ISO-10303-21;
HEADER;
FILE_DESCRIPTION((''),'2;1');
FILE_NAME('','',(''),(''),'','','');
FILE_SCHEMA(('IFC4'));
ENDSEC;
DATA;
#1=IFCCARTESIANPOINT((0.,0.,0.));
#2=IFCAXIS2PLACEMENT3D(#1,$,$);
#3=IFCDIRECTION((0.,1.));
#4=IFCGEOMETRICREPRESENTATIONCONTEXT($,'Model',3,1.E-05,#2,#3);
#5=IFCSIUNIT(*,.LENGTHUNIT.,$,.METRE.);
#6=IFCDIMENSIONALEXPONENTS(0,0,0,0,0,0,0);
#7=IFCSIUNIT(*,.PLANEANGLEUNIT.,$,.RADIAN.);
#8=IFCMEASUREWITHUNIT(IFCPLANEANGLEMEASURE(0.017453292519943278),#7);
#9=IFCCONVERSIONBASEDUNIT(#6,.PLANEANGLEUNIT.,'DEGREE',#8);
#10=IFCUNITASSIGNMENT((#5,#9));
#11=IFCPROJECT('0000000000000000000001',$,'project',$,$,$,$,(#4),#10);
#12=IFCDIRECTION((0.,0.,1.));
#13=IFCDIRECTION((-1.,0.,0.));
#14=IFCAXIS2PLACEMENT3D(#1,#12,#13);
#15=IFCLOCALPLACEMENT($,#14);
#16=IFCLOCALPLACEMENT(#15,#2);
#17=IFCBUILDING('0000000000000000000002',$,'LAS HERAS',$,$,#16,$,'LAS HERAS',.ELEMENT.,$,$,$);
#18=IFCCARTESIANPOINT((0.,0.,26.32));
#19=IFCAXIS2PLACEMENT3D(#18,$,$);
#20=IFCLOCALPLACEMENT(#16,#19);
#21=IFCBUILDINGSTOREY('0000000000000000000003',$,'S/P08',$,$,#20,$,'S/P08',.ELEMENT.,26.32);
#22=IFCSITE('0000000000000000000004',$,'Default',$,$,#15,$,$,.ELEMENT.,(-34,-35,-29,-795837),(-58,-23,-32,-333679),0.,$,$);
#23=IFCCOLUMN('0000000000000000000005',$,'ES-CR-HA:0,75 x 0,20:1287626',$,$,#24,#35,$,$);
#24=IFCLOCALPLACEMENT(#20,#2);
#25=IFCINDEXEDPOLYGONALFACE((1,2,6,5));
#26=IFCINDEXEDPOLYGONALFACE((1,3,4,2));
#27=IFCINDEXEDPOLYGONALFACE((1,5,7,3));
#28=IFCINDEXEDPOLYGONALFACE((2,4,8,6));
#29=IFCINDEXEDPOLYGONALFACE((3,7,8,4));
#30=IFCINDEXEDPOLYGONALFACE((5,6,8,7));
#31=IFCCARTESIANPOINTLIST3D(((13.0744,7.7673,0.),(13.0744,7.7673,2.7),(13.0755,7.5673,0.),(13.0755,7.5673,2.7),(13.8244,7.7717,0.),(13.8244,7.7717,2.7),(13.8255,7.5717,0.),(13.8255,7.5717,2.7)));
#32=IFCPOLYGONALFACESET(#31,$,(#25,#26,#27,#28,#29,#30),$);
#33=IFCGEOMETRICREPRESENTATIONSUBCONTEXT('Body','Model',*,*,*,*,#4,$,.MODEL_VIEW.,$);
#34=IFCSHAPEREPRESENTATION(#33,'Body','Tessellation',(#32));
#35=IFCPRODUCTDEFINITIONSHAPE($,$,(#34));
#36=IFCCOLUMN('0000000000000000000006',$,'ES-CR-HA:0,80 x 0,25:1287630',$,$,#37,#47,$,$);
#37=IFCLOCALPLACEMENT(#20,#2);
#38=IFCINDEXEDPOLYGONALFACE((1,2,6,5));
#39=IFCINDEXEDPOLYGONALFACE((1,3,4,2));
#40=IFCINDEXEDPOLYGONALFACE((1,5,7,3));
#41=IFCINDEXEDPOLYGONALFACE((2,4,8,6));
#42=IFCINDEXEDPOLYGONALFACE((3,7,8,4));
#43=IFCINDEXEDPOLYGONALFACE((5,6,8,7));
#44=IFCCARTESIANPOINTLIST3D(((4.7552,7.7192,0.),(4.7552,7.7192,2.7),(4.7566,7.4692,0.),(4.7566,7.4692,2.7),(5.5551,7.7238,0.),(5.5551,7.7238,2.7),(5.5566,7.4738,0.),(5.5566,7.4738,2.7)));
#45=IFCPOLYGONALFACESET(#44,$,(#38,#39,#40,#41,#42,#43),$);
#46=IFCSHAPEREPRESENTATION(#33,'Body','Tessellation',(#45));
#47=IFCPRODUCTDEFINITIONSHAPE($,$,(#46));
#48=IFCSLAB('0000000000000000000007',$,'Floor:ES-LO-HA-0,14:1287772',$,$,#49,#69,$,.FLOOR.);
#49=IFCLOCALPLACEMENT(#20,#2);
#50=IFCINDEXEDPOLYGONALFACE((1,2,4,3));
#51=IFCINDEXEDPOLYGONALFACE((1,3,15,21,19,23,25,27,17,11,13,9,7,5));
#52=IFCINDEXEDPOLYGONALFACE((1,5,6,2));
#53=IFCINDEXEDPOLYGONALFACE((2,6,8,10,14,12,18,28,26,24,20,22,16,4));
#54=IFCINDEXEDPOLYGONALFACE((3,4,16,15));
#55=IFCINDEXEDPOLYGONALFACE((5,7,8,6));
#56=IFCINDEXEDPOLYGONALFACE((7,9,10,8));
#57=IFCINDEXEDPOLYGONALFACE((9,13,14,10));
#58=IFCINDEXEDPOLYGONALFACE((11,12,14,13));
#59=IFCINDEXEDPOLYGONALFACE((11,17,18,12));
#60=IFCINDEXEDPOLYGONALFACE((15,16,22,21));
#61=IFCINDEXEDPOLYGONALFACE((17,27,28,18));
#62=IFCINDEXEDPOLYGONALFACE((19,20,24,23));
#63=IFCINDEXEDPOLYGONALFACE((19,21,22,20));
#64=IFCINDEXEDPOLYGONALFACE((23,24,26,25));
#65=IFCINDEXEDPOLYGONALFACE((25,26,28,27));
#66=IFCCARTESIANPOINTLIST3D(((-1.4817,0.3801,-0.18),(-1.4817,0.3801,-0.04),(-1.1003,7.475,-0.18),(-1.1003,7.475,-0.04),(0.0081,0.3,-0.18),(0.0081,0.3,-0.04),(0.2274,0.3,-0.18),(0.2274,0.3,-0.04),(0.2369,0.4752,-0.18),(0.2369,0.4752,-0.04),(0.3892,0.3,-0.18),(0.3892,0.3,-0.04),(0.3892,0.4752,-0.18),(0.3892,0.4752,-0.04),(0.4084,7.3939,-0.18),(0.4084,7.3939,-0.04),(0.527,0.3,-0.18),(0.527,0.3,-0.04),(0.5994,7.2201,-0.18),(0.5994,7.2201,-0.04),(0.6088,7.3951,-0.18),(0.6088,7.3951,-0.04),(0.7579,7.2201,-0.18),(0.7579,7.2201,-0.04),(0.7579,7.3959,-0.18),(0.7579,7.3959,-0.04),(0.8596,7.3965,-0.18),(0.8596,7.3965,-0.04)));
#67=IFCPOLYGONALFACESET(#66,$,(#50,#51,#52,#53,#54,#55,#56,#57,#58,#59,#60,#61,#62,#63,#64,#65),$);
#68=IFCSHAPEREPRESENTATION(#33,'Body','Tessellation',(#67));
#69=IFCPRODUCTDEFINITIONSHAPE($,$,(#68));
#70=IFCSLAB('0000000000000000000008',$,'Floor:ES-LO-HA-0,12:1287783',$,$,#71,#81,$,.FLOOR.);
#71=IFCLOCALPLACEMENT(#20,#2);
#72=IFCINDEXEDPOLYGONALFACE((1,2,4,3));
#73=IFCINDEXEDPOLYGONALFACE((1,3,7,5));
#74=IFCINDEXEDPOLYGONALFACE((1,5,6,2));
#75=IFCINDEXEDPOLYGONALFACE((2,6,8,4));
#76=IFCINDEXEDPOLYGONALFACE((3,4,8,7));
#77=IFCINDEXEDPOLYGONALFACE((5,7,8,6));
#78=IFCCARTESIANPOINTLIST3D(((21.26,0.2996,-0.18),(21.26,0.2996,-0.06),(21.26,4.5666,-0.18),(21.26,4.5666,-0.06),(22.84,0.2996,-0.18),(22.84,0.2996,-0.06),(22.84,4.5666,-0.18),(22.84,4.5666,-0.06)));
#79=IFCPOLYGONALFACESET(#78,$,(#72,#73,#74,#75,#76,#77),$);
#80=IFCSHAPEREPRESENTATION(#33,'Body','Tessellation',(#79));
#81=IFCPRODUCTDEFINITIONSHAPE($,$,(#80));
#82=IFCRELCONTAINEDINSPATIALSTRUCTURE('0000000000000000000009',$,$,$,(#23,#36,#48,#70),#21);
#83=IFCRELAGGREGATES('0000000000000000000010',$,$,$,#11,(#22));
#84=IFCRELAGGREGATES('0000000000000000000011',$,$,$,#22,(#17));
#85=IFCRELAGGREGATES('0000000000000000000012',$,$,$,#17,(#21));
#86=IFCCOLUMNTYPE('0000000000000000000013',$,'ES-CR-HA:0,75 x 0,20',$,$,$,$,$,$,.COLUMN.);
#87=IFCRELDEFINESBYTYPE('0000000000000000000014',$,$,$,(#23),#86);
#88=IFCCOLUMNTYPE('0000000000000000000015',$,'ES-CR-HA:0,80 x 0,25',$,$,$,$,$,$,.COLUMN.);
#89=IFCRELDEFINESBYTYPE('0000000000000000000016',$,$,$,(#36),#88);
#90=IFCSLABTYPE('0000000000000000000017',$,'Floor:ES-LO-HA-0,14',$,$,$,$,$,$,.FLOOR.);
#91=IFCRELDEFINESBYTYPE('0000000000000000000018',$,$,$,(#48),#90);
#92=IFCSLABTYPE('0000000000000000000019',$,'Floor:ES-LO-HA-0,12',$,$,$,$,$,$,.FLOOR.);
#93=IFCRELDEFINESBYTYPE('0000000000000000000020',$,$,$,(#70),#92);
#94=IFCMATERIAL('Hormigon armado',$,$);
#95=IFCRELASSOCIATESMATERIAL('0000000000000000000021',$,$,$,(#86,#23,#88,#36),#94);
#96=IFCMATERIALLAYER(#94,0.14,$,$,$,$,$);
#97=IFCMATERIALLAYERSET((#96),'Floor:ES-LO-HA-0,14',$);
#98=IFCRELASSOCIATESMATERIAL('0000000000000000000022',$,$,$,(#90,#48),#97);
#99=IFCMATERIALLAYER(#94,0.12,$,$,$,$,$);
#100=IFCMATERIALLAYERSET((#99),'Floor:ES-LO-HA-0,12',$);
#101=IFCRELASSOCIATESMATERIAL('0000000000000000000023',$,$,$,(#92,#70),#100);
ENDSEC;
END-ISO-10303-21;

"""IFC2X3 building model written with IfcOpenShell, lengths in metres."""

from ifc_helpers import new_model, entity, si_unit, converted_unit, direction, frame, frame_2d, origin, place, context, subcontext, project, spatial, polyline, rectangle, outline, extrude, source, transform, mapped, material, layer, layer_set, layer_usage, type_object, type_shapes, element, save


model = new_model("IFC2X3")

# Units and contexts
model_context = context("Model", 3, precision=1e-05, world=origin(), true_north=direction((0.0, 1.0)))
body_context = subcontext(model_context, "Body", "Model", "MODEL_VIEW")
ifc_project = project(units=[si_unit("LENGTHUNIT", "METRE"), converted_unit("PLANEANGLEUNIT", "DEGREE", entity("IfcPlaneAngleMeasure", 0.017453292519943278), si_unit("PLANEANGLEUNIT", "RADIAN"), dimensions=[0, 0, 0, 0, 0, 0, 0])], contexts=[model_context])

# Site, building, storey
site_placement = place(None, frame((0.0, 0.0, 0.0), z_axis=(0.0, 0.0, 1.0), x_axis=(-1.0, 0.0, 0.0)))
site = spatial("IfcSite", under=ifc_project, at=site_placement, Name="Default", CompositionType="ELEMENT", RefLatitude=(-34, -35, -29, -795837), RefLongitude=(-58, -23, -32, -333679), RefElevation=0.0)
building_placement = place(site_placement, origin())
building = spatial("IfcBuilding", under=site, at=building_placement, Name="LAS HERAS", LongName="LAS HERAS", CompositionType="ELEMENT")
storey_placement = place(building_placement, frame((0.0, 0.0, 26.32)))
storey = spatial("IfcBuildingStorey", under=building, at=storey_placement, Name="S/P08", LongName="S/P08", CompositionType="ELEMENT", Elevation=26.32)

# Columns
ifc_material = material(Name="Hormigon armado")
column_type_1 = type_object("IfcColumnType", Name="ES-CR-HA:0,75 x 0,20", PredefinedType="COLUMN", material=ifc_material)
shared_shape_1 = source(origin(), body_context, "Body", "SweptSolid", [
    extrude(rectangle(XDim=0.75, YDim=0.2, at=frame_2d((0.0, 0.0), x_axis=(1.0, 0.0))), frame((13.4499, 7.6695, 26.32), z_axis=(0.0, 0.0, 1.0), x_axis=(-0.999983, -0.005788, 0.0)), (0.0, 0.0, 1.0), 2.7),
])
type_shapes(column_type_1, [shared_shape_1])
column_1_placement = place(storey_placement, frame((0.0, 0.0, -26.32)))
element("IfcColumn", 1, at=column_1_placement, inside=storey, type_object=column_type_1, material=ifc_material, Name="ES-CR-HA:0,75 x 0,20:1287626", context=body_context, shape_type="MappedRepresentation", body=[
    mapped(shared_shape_1, transform((0.0, 0.0, 0.0), scale=1.0)),
])
column_type_2 = type_object("IfcColumnType", Name="ES-CR-HA:0,80 x 0,25", PredefinedType="COLUMN", material=ifc_material)
shared_shape_2 = source(origin(), body_context, "Body", "SweptSolid", [
    extrude(rectangle(XDim=0.8, YDim=0.25, at=frame_2d((0.0, 0.0), x_axis=(1.0, 0.0))), frame((5.1559, 7.5965, 26.32), z_axis=(0.0, 0.0, 1.0), x_axis=(-0.999983, -0.005788, 0.0)), (0.0, 0.0, 1.0), 2.7),
])
type_shapes(column_type_2, [shared_shape_2])
column_2_placement = place(storey_placement, frame((0.0, 0.0, -26.32)))
element("IfcColumn", 2, at=column_2_placement, inside=storey, type_object=column_type_2, material=ifc_material, Name="ES-CR-HA:0,80 x 0,25:1287630", context=body_context, shape_type="MappedRepresentation", body=[
    mapped(shared_shape_2, transform((0.0, 0.0, 0.0), scale=1.0)),
])

# Slab, openings
ifc_layer_1 = layer(ifc_material, 0.14)
ifc_layer_set_1 = layer_set([ifc_layer_1], Name="Floor:ES-LO-HA-0,14")
ifc_layer_usage_1 = layer_usage(ifc_layer_set_1, "AXIS3", "POSITIVE", 0.0)
slab_type_1 = type_object("IfcSlabType", Name="Floor:ES-LO-HA-0,14", PredefinedType="FLOOR", material=ifc_layer_set_1)
slab_1_placement = place(storey_placement, origin())
slab_1 = element("IfcSlab", 3, at=slab_1_placement, inside=storey, type_object=slab_type_1, material=ifc_layer_usage_1, Name="Floor:ES-LO-HA-0,14:1287772", PredefinedType="FLOOR", context=body_context, shape_type="SweptSolid", body=[
    extrude(outline(polyline([(-0.2993, -3.5591), (-0.1615, -3.5591), (-0.1615, -3.3839), (-0.0091, -3.3839), (0.0003, -3.5591), (0.2196, -3.5591), (1.7094, -3.479), (1.328, 3.6159), (-0.1807, 3.5348), (-0.3811, 3.536), (-0.3717, 3.3611), (-0.5302, 3.3611), (-0.5302, 3.5368), (-0.6319, 3.5374), (-0.2993, -3.5591)])), frame((0.2277, 3.8591, -0.04), z_axis=(0.0, 0.0, -1.0), x_axis=(-1.0, 0.0, 0.0)), (0.0, 0.0, 1.0), 0.14),
])
opening_1_placement = place(slab_1_placement, origin())
element("IfcOpeningElement", 4, at=opening_1_placement, cuts=slab_1, ObjectType="Opening", context=body_context, shape_type="SweptSolid", body=[
    extrude(outline(polyline([(0.2369, 0.4752), (0.2274, 0.3), (0.3892, 0.3), (0.3892, 0.4752), (0.2369, 0.4752)])), frame((0.0, 0.0, -0.04)), (0.0, 0.0, -1.0), 0.14),
])
opening_2_placement = place(slab_1_placement, origin())
element("IfcOpeningElement", 5, at=opening_2_placement, cuts=slab_1, ObjectType="Opening", context=body_context, shape_type="SweptSolid", body=[
    extrude(outline(polyline([(0.7579, 7.2201), (0.7579, 7.3959), (0.6088, 7.3951), (0.5994, 7.2201), (0.7579, 7.2201)])), frame((0.0, 0.0, -0.04)), (0.0, 0.0, -1.0), 0.14),
])

# Slab
ifc_layer_2 = layer(ifc_material, 0.12)
ifc_layer_set_2 = layer_set([ifc_layer_2], Name="Floor:ES-LO-HA-0,12")
ifc_layer_usage_2 = layer_usage(ifc_layer_set_2, "AXIS3", "POSITIVE", 0.0)
slab_type_2 = type_object("IfcSlabType", Name="Floor:ES-LO-HA-0,12", PredefinedType="FLOOR", material=ifc_layer_set_2)
slab_2_placement = place(storey_placement, origin())
element("IfcSlab", 6, at=slab_2_placement, inside=storey, type_object=slab_type_2, material=ifc_layer_usage_2, Name="Floor:ES-LO-HA-0,12:1287783", PredefinedType="FLOOR", context=body_context, shape_type="SweptSolid", body=[
    extrude(rectangle(XDim=4.2671, YDim=1.58, at=frame_2d((0.0, 0.0), x_axis=(1.0, 0.0))), frame((22.05, 2.4331, -0.06), z_axis=(0.0, 0.0, -1.0), x_axis=(0.0, 1.0, 0.0)), (0.0, 0.0, 1.0), 0.12),
])

save(model, "model.ifc")
